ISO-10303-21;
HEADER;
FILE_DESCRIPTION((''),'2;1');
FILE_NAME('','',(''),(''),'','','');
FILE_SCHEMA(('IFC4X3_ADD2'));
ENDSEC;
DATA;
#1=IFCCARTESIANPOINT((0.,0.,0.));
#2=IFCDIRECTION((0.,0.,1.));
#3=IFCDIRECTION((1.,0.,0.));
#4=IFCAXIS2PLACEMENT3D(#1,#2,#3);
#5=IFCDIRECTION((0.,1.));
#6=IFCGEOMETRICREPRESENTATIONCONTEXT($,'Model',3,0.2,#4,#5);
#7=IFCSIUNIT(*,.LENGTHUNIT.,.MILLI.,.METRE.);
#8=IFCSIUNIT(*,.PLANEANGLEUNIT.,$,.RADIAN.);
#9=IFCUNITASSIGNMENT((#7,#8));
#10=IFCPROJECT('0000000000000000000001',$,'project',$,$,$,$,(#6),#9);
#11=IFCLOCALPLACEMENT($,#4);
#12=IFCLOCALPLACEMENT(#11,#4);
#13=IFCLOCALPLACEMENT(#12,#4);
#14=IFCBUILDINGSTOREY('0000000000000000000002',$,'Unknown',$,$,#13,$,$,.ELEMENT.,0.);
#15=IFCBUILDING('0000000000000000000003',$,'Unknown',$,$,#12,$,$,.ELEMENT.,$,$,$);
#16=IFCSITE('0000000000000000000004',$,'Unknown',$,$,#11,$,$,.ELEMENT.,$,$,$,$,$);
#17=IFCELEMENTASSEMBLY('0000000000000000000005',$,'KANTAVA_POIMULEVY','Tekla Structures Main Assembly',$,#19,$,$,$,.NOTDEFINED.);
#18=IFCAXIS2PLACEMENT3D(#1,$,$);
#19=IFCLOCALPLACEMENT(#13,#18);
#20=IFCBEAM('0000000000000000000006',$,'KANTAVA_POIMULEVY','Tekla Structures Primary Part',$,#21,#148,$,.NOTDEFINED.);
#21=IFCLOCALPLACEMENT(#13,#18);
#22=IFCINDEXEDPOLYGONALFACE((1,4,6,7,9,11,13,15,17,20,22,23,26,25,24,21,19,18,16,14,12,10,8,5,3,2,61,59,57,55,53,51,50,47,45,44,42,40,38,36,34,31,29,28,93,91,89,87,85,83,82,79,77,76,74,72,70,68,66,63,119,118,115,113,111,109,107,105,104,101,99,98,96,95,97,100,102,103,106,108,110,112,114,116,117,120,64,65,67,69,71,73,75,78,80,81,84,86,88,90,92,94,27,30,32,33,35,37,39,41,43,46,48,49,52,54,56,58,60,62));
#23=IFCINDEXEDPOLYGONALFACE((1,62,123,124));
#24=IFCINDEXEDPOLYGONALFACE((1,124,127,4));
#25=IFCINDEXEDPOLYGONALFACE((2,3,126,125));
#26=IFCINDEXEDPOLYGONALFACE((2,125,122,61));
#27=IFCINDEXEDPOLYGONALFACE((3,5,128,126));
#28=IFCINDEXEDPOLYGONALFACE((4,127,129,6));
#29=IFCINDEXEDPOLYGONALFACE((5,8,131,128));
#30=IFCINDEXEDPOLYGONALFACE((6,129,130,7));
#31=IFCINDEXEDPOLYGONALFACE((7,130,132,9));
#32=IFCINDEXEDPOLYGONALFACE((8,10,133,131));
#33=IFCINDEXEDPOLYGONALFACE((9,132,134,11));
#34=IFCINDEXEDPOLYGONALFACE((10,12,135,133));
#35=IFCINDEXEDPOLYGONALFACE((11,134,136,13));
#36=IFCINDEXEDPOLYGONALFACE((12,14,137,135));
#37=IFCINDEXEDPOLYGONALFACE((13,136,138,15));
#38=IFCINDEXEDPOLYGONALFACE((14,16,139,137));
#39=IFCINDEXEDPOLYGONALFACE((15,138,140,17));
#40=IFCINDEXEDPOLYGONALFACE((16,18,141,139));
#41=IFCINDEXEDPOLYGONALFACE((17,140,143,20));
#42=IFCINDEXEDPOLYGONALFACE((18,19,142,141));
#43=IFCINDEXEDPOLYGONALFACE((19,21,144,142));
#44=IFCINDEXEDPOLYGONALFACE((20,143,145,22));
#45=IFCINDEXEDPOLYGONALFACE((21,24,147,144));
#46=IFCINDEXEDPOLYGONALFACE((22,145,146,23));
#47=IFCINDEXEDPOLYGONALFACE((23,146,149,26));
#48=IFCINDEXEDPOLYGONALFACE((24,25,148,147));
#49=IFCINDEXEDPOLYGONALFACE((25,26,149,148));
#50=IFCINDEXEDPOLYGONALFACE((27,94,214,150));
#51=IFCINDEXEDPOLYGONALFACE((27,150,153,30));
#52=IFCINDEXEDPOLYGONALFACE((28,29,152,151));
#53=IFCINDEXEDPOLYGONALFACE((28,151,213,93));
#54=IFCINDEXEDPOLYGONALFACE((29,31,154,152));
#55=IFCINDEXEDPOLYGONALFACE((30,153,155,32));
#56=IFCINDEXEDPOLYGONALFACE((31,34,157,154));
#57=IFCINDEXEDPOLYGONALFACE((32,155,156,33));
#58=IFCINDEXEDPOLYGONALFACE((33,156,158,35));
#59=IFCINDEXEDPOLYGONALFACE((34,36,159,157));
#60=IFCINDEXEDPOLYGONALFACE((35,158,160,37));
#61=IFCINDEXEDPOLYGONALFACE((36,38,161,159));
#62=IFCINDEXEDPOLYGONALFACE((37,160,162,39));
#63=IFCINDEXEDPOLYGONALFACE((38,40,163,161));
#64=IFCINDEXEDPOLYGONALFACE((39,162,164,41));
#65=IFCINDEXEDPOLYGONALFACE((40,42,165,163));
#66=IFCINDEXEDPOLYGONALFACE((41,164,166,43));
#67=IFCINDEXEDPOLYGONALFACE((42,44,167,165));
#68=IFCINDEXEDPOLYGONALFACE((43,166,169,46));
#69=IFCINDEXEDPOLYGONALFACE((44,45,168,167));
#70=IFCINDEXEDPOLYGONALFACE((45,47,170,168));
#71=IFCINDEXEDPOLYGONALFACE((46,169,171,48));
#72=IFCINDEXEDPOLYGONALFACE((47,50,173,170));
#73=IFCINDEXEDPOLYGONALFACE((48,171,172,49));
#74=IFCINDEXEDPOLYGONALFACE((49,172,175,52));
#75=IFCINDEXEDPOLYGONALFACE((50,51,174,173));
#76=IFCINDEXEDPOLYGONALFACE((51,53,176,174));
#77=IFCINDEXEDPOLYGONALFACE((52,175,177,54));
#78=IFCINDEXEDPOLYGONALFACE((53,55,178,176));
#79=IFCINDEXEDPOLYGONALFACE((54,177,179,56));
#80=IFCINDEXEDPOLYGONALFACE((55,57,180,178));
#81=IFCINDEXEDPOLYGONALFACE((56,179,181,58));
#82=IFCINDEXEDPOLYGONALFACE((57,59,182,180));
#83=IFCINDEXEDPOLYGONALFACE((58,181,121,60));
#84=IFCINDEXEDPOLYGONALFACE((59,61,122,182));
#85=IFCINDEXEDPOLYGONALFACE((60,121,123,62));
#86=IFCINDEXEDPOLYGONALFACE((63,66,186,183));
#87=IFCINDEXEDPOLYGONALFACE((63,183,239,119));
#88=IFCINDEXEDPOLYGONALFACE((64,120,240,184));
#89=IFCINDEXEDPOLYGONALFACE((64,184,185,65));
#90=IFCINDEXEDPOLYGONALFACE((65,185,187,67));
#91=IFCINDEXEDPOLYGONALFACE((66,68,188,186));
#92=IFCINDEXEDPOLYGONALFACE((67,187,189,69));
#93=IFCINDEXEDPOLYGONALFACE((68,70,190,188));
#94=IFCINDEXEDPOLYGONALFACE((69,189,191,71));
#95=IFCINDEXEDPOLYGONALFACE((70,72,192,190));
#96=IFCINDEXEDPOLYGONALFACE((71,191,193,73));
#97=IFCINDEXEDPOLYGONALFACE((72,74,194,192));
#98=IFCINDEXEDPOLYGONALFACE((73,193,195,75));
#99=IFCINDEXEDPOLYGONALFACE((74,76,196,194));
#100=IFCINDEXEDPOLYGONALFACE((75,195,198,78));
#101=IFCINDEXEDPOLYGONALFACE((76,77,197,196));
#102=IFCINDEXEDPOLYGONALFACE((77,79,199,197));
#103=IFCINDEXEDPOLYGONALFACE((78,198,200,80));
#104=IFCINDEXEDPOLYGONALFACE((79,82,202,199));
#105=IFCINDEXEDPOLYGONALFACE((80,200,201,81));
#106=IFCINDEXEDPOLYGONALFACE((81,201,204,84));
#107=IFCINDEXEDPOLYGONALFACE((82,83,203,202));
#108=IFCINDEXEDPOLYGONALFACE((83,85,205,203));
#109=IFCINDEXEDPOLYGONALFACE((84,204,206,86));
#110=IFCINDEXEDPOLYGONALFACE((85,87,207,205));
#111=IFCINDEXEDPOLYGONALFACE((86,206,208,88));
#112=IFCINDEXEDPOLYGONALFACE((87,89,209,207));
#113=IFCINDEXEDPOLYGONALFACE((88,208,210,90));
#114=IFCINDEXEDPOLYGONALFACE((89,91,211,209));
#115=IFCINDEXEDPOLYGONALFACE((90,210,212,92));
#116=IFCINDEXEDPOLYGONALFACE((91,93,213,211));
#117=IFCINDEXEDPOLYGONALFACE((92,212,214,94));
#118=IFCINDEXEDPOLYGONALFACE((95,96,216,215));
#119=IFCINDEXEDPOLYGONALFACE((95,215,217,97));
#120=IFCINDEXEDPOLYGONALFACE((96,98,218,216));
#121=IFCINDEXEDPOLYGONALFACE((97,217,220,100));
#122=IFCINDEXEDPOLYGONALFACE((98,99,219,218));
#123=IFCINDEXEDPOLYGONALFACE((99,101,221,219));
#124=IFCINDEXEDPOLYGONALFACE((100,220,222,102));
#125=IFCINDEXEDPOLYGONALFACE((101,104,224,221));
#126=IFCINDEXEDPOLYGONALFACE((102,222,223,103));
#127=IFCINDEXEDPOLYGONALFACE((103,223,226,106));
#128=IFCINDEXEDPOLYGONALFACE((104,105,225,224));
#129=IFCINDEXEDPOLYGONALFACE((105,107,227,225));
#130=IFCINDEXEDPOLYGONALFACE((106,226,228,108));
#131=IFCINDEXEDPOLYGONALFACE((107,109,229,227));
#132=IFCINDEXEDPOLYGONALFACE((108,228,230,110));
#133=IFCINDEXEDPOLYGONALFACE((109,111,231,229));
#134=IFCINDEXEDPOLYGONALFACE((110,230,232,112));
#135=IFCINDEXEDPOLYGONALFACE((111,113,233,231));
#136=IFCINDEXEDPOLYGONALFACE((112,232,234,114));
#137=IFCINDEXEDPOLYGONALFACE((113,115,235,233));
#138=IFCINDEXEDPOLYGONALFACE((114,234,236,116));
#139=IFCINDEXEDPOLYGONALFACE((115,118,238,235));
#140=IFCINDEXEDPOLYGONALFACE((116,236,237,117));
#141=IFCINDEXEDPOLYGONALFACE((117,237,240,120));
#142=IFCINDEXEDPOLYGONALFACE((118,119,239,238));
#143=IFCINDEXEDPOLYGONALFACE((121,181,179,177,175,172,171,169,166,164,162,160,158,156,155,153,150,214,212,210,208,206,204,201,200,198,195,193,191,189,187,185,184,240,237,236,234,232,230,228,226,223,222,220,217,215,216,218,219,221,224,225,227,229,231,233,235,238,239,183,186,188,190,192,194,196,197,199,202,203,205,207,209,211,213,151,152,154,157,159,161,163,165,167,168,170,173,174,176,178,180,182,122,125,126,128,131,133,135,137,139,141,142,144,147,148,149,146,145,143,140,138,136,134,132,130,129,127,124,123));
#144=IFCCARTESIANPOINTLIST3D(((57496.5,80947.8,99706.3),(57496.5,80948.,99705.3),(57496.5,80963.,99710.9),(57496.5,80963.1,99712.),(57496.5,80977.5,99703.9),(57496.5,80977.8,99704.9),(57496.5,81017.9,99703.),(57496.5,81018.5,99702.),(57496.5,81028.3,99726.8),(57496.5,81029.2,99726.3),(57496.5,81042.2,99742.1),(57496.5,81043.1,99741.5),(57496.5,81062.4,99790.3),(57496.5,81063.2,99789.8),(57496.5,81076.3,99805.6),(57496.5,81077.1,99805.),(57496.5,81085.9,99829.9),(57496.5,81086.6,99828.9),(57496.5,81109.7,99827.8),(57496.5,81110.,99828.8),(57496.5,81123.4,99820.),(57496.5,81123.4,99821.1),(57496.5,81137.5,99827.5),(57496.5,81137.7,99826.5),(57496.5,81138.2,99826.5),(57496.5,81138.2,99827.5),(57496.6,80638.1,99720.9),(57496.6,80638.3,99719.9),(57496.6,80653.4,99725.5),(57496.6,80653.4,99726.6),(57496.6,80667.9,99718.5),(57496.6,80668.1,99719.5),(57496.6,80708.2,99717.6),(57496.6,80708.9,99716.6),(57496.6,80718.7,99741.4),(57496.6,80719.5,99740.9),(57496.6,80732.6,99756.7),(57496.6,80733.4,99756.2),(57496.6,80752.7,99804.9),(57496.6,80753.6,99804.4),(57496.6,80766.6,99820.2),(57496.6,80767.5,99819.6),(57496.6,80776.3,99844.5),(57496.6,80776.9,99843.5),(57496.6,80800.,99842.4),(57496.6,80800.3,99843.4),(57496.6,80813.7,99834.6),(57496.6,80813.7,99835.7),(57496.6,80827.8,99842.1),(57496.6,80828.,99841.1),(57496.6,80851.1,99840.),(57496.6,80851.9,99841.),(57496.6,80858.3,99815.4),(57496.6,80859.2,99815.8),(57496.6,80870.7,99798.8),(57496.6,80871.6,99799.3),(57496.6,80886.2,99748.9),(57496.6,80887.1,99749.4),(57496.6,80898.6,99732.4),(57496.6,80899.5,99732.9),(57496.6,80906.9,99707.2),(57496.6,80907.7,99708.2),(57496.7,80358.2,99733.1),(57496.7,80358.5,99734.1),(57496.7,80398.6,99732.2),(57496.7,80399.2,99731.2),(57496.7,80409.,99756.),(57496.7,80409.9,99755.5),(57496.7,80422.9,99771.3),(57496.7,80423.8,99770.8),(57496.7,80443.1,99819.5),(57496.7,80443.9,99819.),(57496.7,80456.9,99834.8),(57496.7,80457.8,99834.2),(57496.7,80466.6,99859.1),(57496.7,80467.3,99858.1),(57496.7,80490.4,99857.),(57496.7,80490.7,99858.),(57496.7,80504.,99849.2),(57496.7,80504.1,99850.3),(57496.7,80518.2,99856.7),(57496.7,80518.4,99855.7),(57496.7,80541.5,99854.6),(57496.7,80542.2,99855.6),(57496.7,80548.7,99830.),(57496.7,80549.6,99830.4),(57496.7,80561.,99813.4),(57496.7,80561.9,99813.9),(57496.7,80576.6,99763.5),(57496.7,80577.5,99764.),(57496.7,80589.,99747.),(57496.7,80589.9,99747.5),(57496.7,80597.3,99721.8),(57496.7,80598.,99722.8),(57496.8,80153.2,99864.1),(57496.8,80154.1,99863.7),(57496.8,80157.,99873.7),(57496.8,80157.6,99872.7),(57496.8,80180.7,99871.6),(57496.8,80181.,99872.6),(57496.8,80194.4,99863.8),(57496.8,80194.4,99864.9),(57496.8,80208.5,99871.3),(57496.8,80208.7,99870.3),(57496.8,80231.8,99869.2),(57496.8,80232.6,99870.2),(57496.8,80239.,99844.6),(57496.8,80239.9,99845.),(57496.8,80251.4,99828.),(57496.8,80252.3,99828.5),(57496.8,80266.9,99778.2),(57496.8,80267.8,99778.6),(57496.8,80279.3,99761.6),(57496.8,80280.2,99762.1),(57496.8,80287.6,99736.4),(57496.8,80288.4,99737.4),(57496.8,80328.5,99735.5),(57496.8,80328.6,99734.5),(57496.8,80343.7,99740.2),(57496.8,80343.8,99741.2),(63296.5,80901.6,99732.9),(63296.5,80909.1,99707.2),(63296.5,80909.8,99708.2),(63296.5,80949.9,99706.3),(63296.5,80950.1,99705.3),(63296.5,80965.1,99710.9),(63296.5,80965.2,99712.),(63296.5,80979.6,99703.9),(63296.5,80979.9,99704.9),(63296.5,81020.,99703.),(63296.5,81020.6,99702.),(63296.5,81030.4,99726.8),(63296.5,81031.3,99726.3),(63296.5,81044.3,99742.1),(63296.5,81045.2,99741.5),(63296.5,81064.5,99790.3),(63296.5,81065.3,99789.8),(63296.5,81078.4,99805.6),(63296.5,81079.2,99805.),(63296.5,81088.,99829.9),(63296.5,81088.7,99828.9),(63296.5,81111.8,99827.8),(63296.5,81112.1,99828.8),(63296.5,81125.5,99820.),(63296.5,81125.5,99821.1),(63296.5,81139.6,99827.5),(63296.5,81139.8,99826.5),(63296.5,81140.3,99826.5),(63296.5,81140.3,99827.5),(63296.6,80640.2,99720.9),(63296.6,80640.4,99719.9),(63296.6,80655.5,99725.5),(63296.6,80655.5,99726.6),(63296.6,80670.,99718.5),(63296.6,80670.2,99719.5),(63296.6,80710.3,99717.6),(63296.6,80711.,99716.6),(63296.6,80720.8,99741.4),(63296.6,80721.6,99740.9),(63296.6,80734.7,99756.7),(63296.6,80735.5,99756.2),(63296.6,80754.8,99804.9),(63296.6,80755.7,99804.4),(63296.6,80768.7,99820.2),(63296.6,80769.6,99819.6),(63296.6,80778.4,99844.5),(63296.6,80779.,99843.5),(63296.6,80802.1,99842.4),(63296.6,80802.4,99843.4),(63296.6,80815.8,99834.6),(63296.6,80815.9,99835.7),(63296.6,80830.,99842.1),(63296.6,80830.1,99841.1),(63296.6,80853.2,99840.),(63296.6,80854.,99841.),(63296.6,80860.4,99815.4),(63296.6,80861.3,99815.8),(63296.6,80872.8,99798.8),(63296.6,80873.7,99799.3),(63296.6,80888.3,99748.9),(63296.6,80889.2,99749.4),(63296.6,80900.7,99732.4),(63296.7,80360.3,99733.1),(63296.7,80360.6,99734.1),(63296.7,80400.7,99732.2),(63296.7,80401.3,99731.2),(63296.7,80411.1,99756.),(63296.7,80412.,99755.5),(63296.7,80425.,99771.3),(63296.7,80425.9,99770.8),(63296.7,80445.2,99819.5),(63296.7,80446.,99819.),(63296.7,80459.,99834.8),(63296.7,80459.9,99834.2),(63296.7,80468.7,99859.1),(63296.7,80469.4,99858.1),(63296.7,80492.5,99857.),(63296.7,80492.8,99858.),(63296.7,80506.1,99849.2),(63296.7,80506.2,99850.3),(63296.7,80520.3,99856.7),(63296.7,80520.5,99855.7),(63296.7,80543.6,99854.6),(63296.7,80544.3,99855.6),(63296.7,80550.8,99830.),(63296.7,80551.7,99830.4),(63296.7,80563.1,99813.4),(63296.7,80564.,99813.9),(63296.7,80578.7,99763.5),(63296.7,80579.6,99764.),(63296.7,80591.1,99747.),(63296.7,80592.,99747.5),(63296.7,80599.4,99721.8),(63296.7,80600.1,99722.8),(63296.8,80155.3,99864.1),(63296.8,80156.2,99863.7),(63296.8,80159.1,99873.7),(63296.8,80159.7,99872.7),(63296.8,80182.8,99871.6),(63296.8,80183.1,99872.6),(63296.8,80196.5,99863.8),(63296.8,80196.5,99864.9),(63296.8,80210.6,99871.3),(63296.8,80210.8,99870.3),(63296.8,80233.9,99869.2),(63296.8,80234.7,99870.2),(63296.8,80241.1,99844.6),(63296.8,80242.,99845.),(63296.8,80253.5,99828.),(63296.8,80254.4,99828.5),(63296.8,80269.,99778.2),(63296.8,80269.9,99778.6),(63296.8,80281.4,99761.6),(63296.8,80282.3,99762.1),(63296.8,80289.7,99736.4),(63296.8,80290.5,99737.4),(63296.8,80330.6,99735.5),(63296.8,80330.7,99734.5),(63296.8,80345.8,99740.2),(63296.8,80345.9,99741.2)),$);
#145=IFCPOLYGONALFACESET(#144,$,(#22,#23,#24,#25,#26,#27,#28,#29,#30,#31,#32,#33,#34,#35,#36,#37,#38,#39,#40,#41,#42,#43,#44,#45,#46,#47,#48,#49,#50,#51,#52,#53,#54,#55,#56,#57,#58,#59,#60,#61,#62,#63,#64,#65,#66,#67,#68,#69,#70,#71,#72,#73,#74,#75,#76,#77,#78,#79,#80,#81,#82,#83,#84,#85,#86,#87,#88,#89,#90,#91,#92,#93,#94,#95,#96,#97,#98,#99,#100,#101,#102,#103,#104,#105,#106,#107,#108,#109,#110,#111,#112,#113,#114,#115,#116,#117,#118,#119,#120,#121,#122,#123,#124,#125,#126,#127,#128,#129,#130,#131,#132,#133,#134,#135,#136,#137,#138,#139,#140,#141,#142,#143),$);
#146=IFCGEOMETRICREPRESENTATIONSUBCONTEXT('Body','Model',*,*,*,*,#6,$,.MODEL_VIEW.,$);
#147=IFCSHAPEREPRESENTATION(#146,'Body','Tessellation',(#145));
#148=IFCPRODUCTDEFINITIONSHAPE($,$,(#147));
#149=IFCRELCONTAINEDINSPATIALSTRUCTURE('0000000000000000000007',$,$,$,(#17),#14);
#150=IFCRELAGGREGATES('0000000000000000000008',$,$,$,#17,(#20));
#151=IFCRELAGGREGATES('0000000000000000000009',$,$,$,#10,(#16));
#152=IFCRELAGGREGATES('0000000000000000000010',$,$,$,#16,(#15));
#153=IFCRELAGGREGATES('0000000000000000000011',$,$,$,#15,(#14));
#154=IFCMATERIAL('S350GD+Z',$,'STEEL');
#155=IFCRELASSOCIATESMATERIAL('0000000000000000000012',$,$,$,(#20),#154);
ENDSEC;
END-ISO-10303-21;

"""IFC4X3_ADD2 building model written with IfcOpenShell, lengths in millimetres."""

from ifc_helpers import new_model, si_unit, direction, frame, origin_with_axes, place, context, subcontext, project, spatial, line, indexed_curve, outline, extrude, material, element, aggregate, save


model = new_model("IFC4X3_ADD2")

# Units and contexts
model_context = context("Model", 3, precision=0.2, world=origin_with_axes(), true_north=direction((0.0, 1.0)))
body_context = subcontext(model_context, "Body", "Model", "MODEL_VIEW")
ifc_project = project(units=[si_unit("LENGTHUNIT", "METRE", prefix="MILLI"), si_unit("PLANEANGLEUNIT", "RADIAN")], contexts=[model_context])

# Site, building, storey
site_placement = place(None, origin_with_axes())
site = spatial("IfcSite", under=ifc_project, at=site_placement, Name="Unknown", CompositionType="ELEMENT")
building_placement = place(site_placement, origin_with_axes())
building = spatial("IfcBuilding", under=site, at=building_placement, Name="Unknown", CompositionType="ELEMENT")
storey_placement = place(building_placement, origin_with_axes())
storey = spatial("IfcBuildingStorey", under=building, at=storey_placement, Name="Unknown", CompositionType="ELEMENT", Elevation=0.0)

# Element assembly, beam
ifc_material_1 = material(Name="S350GD+Z", Category="STEEL")
assembly_1_placement = place(storey_placement, frame((63296.6, 80658.3, 99784.6), z_axis=(-0.000363, 0.99889, -0.047106), x_axis=(-1.0, -0.000363, 0.0)))
assembly_1 = element("IfcElementAssembly", 1, at=assembly_1_placement, inside=storey, Name="KANTAVA_POIMULEVY", Description="Tekla Structures Main Assembly", PredefinedType="NOTDEFINED")
beam_1_placement = place(assembly_1_placement, origin_with_axes())
beam_1 = element("IfcBeam", 2, at=beam_1_placement, material=ifc_material_1, Name="KANTAVA_POIMULEVY", Description="Tekla Structures Primary Part", PredefinedType="NOTDEFINED", context=body_context, shape_type="SolidModel", body=[
    extrude(outline(indexed_curve([(479.5, 65.5), (478.8, 65.5), (465.0, 58.5), (451.2, 65.5), (427.1, 65.5), (418.6, 40.7), (405.5, 24.8), (387.6, -24.3), (374.5, -40.2), (365.1, -64.5), (325.0, -64.5), (310.0, -58.1), (295.0, -64.5), (254.8, -64.5), (245.5, -40.2), (232.4, -24.3), (214.5, 24.8), (201.4, 40.7), (192.9, 65.5), (168.8, 65.5), (155.0, 58.5), (141.2, 65.5), (117.1, 65.5), (108.6, 40.7), (95.5, 24.8), (77.6, -24.3), (64.5, -40.2), (55.1, -64.5), (15.0, -64.5), (0.0, -58.1), (-15.0, -64.5), (-55.2, -64.5), (-64.5, -40.2), (-77.6, -24.3), (-95.5, 24.8), (-108.6, 40.7), (-117.2, 65.5), (-141.2, 65.5), (-155.0, 58.5), (-168.8, 65.5), (-192.9, 65.5), (-201.4, 40.7), (-214.5, 24.8), (-232.4, -24.3), (-245.5, -40.2), (-254.9, -64.5), (-295.0, -64.5), (-310.0, -58.1), (-325.0, -64.5), (-365.2, -64.5), (-374.5, -40.2), (-387.6, -24.3), (-405.5, 24.8), (-418.6, 40.7), (-427.1, 65.5), (-451.2, 65.5), (-465.0, 58.5), (-478.8, 65.5), (-502.9, 65.5), (-506.2, 55.7), (-505.2, 55.4), (-502.1, 64.5), (-479.0, 64.5), (-465.0, 57.3), (-451.0, 64.5), (-427.9, 64.5), (-419.5, 40.2), (-406.4, 24.3), (-388.5, -24.8), (-375.4, -40.7), (-365.9, -65.5), (-324.8, -65.5), (-310.0, -59.1), (-295.2, -65.5), (-254.2, -65.5), (-244.6, -40.7), (-231.5, -24.8), (-213.6, 24.3), (-200.5, 40.2), (-192.1, 64.5), (-169.0, 64.5), (-155.0, 57.3), (-141.0, 64.5), (-117.9, 64.5), (-109.5, 40.2), (-96.4, 24.3), (-78.5, -24.8), (-65.4, -40.7), (-55.9, -65.5), (-14.8, -65.5), (0.0, -59.1), (14.8, -65.5), (55.8, -65.5), (65.4, -40.7), (78.5, -24.8), (96.4, 24.3), (109.5, 40.2), (117.8, 64.5), (141.0, 64.5), (155.0, 57.3), (169.0, 64.5), (192.1, 64.5), (200.5, 40.2), (213.6, 24.3), (231.5, -24.8), (244.6, -40.7), (254.1, -65.5), (295.2, -65.5), (310.0, -59.1), (324.8, -65.5), (365.8, -65.5), (375.4, -40.7), (388.5, -24.8), (406.4, 24.3), (419.5, 40.2), (427.9, 64.5), (451.0, 64.5), (465.0, 57.3), (479.0, 64.5), (479.5, 64.5)], segments=[line(1, 2, 3, 4, 5, 6, 7, 8, 9, 10, 11, 12, 13, 14, 15, 16, 17, 18, 19, 20, 21, 22, 23, 24, 25, 26, 27, 28, 29, 30, 31, 32, 33, 34, 35, 36, 37, 38, 39, 40, 41, 42, 43, 44, 45, 46, 47, 48, 49, 50, 51, 52, 53, 54, 55, 56, 57, 58, 59, 60, 61, 62, 63, 64, 65, 66, 67, 68, 69, 70, 71, 72, 73, 74, 75, 76, 77, 78, 79, 80, 81, 82, 83, 84, 85, 86, 87, 88, 89, 90, 91, 92, 93, 94, 95, 96, 97, 98, 99, 100, 101, 102, 103, 104, 105, 106, 107, 108, 109, 110, 111, 112, 113, 114, 115, 116, 117, 118, 119, 120, 1)])), frame((0.0, 0.0, 0.0), z_axis=(-1.0, 0.0, 0.0), x_axis=(0.0, 0.0, 1.0)), (0.0, 0.0, -1.0), 5800.0),
])
aggregate(assembly_1, [beam_1])

save(model, "model.ifc")
